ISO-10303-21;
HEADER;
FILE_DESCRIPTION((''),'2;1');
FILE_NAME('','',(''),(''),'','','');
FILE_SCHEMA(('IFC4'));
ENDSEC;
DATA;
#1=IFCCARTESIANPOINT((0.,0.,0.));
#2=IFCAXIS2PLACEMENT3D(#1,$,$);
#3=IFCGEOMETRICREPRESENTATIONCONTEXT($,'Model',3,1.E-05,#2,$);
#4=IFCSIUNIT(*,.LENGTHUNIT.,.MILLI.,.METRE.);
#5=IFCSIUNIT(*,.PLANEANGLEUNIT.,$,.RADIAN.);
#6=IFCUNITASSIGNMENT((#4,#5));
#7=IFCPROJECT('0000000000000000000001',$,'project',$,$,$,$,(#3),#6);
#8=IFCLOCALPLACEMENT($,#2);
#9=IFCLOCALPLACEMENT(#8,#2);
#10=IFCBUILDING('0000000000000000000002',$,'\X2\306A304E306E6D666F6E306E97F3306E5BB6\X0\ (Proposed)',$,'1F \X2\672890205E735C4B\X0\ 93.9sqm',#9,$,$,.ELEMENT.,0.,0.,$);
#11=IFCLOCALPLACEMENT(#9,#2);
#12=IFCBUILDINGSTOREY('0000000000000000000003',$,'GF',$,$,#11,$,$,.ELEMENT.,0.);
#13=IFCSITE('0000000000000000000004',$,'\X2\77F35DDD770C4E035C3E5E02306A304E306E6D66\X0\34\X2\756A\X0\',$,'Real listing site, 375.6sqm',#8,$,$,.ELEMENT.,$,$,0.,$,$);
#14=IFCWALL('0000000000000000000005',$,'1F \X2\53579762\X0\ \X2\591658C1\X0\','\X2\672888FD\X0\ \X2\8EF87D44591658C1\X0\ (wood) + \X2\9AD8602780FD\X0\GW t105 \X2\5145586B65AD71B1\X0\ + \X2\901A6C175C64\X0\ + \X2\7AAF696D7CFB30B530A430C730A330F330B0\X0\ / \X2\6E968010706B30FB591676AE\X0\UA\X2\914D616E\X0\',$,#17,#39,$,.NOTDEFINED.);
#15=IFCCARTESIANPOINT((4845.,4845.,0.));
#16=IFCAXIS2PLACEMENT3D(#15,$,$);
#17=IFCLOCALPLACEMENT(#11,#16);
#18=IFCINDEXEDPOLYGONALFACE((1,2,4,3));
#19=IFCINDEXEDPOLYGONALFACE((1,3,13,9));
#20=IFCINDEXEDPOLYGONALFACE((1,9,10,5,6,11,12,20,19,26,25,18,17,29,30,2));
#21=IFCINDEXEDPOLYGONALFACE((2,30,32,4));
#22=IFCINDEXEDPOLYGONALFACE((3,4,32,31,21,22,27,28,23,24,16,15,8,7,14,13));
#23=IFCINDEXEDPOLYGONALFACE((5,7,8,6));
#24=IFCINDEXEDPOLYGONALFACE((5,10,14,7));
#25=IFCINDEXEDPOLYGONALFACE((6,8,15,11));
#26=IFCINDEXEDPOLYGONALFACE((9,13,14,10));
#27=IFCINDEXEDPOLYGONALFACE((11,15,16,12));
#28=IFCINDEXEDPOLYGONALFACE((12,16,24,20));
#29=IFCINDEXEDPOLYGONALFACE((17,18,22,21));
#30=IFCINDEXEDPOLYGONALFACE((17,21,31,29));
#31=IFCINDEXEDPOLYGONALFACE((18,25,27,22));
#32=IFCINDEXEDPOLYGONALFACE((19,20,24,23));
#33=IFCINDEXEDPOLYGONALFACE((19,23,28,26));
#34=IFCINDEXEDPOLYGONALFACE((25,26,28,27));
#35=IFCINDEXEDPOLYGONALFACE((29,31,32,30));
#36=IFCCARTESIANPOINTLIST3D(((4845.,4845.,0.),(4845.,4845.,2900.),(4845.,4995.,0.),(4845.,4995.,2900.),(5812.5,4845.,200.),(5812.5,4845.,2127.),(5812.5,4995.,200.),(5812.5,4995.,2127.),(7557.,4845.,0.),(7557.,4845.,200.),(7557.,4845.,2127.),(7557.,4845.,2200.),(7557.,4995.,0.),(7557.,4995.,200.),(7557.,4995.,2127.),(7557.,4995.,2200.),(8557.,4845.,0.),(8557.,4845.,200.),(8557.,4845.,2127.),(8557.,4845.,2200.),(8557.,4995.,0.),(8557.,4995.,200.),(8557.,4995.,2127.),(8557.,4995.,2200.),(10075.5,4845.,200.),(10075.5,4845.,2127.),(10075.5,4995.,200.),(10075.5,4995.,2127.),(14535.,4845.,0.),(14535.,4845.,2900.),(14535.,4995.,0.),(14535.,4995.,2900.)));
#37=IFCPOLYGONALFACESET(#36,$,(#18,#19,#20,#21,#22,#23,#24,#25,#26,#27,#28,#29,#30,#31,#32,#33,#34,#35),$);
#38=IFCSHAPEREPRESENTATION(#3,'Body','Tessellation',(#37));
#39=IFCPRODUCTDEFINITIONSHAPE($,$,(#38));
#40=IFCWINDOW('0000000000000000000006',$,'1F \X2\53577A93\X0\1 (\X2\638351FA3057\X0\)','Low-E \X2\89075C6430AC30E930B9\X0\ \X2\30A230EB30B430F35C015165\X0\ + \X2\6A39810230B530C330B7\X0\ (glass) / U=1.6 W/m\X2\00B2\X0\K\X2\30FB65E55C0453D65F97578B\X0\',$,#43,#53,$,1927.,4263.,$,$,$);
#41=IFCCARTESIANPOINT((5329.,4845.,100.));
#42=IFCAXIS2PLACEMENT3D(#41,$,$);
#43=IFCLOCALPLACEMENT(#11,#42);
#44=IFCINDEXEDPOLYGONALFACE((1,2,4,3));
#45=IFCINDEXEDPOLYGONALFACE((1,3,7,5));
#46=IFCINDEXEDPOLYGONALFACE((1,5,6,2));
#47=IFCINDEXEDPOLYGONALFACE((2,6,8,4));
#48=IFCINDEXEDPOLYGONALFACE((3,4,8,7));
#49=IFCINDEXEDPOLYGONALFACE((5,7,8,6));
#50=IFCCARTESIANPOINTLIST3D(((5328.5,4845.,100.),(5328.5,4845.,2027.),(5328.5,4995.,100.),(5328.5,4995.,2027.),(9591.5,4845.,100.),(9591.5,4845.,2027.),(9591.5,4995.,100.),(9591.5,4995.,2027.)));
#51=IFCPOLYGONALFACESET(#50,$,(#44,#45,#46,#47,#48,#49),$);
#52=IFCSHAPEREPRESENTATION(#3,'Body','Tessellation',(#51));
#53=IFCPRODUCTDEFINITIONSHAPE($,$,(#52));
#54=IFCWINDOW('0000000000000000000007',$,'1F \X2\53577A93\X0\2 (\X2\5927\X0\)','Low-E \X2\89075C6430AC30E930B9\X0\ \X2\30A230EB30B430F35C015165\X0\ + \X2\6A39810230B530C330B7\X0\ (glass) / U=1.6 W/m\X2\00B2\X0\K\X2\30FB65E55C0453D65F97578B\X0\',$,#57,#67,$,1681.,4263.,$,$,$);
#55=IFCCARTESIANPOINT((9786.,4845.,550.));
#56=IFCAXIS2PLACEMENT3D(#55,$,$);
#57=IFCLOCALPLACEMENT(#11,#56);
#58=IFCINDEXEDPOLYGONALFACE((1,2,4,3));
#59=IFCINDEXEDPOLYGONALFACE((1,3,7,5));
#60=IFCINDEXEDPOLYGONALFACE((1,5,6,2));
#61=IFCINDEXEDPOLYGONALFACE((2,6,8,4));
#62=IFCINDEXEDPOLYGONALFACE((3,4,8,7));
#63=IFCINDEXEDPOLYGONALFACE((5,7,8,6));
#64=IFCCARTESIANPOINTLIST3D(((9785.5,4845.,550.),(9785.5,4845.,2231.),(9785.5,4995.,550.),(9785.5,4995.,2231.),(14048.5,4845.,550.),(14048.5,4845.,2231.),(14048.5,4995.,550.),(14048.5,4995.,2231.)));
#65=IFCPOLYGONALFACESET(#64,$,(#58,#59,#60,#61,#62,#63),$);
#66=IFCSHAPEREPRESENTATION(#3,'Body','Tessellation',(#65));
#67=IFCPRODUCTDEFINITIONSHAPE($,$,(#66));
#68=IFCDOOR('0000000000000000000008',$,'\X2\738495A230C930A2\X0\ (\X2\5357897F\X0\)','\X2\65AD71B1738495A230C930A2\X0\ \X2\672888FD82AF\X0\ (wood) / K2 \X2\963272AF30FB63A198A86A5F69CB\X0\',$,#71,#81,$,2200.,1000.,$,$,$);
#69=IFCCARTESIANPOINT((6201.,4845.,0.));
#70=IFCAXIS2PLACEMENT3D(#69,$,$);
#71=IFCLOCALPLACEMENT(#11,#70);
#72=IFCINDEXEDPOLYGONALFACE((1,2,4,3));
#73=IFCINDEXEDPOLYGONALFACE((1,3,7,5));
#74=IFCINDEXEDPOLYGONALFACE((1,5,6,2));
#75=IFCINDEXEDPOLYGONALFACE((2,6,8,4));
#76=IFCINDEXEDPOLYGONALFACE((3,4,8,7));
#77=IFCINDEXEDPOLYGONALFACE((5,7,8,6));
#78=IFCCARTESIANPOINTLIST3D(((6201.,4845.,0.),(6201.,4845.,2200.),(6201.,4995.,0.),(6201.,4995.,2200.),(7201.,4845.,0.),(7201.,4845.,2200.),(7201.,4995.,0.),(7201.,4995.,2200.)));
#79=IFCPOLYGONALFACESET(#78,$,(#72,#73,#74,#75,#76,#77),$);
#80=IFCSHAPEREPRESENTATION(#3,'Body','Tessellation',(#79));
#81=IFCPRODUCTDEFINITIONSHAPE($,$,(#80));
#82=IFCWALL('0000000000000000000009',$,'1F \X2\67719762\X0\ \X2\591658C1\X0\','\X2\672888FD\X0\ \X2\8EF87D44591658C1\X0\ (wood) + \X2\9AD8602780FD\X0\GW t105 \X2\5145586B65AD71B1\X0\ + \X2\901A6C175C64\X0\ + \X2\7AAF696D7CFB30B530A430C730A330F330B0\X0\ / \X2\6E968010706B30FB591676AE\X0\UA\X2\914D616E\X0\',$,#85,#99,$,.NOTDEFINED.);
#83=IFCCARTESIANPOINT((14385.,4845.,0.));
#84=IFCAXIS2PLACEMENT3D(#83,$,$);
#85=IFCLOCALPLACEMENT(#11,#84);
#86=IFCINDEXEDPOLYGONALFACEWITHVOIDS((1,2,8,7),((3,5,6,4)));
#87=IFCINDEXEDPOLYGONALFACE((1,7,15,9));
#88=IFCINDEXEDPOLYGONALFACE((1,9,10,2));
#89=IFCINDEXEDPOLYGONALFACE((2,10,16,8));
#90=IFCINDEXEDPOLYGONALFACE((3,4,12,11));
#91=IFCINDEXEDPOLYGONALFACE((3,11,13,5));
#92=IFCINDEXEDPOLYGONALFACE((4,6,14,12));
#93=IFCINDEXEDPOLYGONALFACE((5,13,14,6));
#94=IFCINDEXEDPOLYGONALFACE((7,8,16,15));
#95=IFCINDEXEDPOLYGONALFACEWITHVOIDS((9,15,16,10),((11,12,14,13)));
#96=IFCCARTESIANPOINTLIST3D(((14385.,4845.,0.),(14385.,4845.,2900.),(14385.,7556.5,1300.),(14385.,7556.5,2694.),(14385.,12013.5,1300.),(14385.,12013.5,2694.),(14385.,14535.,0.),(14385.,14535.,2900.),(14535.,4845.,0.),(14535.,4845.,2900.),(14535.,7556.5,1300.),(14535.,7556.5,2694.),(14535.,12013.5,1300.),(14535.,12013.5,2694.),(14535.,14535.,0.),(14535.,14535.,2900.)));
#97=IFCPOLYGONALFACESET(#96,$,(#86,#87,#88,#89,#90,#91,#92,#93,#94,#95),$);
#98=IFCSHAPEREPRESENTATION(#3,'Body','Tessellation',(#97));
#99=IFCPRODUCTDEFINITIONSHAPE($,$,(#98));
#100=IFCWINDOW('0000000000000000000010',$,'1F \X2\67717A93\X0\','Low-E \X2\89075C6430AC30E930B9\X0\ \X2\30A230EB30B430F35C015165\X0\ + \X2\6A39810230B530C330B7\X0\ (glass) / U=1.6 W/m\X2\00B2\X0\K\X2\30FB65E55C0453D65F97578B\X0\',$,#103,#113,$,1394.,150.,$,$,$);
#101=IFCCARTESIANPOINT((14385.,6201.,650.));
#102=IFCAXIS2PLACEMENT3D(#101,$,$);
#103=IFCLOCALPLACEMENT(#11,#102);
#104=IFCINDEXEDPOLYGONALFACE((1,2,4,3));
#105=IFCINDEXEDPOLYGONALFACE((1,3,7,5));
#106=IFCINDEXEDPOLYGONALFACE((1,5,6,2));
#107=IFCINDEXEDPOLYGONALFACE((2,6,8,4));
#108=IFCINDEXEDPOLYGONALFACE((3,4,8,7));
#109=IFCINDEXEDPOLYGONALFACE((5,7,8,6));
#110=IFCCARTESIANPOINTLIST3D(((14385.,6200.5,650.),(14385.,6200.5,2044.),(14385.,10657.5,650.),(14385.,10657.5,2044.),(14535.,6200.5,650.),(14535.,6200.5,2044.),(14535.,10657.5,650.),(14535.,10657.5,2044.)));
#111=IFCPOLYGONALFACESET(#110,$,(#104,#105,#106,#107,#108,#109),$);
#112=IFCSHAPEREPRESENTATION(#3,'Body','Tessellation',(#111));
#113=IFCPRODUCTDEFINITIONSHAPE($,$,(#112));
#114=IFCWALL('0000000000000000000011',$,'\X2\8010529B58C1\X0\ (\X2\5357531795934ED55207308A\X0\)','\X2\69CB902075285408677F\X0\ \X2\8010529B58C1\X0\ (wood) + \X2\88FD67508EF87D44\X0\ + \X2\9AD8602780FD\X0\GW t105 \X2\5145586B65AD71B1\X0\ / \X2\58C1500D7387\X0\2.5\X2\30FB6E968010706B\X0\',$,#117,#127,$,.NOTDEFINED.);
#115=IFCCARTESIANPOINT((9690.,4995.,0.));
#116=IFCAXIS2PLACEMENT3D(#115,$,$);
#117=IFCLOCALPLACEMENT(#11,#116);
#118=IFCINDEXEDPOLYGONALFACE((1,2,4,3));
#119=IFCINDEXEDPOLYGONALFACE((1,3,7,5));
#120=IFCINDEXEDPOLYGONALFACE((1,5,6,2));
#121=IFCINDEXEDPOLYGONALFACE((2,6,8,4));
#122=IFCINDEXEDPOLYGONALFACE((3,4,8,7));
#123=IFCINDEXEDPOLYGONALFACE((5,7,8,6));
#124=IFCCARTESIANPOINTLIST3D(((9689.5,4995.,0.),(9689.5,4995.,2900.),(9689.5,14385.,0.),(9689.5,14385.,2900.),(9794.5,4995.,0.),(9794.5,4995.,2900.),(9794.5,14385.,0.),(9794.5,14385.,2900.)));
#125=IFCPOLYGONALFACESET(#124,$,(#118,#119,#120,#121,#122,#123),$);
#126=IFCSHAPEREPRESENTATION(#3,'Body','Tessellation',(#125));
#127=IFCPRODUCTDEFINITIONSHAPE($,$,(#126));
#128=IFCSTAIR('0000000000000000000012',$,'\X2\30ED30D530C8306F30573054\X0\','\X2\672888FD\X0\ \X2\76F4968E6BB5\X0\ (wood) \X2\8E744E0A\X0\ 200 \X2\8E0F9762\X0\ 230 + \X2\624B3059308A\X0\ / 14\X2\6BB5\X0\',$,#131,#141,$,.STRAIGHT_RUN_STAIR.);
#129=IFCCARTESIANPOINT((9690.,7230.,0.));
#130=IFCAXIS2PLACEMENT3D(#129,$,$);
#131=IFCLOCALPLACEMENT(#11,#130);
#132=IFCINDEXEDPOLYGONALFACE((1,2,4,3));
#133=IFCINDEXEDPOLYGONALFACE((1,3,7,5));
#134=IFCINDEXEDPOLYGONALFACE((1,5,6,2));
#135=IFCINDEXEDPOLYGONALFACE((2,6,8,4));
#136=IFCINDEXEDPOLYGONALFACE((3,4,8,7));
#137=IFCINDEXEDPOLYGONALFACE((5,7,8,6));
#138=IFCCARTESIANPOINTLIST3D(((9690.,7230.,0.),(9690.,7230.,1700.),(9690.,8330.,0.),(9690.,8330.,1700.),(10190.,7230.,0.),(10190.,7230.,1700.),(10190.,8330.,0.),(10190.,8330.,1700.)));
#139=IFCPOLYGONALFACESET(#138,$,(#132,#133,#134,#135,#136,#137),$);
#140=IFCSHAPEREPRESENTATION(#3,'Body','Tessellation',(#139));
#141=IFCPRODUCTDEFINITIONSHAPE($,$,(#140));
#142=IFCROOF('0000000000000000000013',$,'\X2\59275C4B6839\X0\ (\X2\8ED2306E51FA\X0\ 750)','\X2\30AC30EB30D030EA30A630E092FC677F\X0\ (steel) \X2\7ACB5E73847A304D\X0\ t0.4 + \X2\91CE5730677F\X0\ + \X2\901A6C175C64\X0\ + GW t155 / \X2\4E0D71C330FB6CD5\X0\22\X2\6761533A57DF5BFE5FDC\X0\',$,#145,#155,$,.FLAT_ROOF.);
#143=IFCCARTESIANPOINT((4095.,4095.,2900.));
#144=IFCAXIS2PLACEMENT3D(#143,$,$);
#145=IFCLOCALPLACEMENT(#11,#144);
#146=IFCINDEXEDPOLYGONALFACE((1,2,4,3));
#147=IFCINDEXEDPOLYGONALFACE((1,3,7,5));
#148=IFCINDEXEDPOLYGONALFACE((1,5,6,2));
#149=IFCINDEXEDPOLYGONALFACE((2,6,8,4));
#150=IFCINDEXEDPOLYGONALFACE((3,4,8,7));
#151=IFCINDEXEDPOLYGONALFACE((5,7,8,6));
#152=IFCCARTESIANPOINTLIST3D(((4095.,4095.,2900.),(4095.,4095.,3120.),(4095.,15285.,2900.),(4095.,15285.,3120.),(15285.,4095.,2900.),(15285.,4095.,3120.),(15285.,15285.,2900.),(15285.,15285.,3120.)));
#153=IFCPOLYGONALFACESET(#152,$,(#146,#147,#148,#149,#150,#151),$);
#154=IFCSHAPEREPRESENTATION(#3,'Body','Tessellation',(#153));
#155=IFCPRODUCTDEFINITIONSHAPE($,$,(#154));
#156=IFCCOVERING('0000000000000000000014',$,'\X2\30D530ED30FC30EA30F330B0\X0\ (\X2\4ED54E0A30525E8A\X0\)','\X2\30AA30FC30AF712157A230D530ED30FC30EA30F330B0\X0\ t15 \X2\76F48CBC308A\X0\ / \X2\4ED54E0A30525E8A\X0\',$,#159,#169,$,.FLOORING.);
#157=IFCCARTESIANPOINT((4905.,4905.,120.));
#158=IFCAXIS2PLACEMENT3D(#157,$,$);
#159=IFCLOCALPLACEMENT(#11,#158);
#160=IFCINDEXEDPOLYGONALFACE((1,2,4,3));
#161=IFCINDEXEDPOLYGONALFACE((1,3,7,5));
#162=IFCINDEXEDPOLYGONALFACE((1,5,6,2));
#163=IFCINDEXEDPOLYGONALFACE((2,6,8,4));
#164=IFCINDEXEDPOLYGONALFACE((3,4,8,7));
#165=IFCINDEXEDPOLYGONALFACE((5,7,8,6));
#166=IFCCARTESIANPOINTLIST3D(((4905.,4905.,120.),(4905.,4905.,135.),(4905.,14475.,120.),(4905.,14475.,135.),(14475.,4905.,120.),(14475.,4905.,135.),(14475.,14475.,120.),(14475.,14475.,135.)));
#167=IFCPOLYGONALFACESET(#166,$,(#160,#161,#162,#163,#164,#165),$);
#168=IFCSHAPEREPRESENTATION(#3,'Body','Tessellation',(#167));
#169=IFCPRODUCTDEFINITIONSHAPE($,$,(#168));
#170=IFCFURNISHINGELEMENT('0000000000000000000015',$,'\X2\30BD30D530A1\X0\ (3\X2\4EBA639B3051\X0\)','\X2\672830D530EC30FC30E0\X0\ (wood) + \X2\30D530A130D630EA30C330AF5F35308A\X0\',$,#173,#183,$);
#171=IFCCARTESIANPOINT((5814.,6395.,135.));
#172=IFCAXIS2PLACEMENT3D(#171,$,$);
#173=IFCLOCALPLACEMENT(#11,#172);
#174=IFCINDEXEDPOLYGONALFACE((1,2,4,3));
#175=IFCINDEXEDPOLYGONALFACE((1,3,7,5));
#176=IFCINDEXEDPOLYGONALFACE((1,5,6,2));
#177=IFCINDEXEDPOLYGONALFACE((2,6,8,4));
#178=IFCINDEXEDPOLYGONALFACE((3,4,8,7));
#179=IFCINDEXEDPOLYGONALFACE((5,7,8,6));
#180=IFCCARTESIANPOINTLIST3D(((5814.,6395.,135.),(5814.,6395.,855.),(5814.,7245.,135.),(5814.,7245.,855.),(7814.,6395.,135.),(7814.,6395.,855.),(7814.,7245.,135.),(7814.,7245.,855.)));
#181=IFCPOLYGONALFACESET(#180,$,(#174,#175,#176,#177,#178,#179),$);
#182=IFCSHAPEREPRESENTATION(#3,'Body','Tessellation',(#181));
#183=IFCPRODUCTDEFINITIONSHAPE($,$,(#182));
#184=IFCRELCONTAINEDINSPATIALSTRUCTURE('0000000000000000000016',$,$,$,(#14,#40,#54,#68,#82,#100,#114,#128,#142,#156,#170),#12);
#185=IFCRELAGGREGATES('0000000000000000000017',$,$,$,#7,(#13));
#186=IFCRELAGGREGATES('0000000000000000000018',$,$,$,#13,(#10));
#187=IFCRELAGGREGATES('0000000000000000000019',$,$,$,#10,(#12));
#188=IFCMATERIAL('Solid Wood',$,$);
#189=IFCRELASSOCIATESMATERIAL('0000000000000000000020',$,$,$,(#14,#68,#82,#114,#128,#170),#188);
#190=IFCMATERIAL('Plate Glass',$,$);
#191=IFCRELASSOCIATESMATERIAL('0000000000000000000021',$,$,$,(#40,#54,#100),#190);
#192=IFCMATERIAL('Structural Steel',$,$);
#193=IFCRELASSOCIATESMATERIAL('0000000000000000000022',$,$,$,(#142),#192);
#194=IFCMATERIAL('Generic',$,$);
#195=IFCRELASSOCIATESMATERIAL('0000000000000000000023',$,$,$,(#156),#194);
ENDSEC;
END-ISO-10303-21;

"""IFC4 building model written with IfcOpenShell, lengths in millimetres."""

from ifc_helpers import new_model, si_unit, frame, frame_2d, origin, place, context, project, spatial, rectangle, extrude, material, element, fill, save


model = new_model("IFC4")

# Units and contexts
model_context = context("Model", 3, precision=1e-05, world=origin())
ifc_project = project(units=[si_unit("LENGTHUNIT", "METRE", prefix="MILLI"), si_unit("PLANEANGLEUNIT", "RADIAN")], contexts=[model_context])

# Site, building, storey
site_placement = place(None, origin())
site = spatial("IfcSite", under=ifc_project, at=site_placement, Name="石川県七尾市なぎの浦34番", ObjectType="Real listing site, 375.6sqm", CompositionType="ELEMENT", RefElevation=0.0)
building_placement = place(site_placement, origin())
building = spatial("IfcBuilding", under=site, at=building_placement, Name="なぎの浦潮の音の家 (Proposed)", ObjectType="1F 木造平屋 93.9sqm", CompositionType="ELEMENT", ElevationOfRefHeight=0.0, ElevationOfTerrain=0.0)
storey_placement = place(building_placement, origin())
storey = spatial("IfcBuildingStorey", under=building, at=storey_placement, Name="GF", CompositionType="ELEMENT", Elevation=0.0)

# Shared definitions
ifc_material_1 = material(Name="Solid Wood")

# Wall, openings, windows, door
wall_1_placement = place(storey_placement, frame((4845.0, 4845.0, 0.0)))
wall_1 = element("IfcWall", 1, at=wall_1_placement, inside=storey, material=ifc_material_1, Name="1F 南面 外壁", Description="木製 軸組外壁 (wood) + 高性能GW t105 充填断熱 + 通気層 + 窯業系サイディング / 準耐火・外皮UA配慮", PredefinedType="NOTDEFINED", context=model_context, shape_type="SweptSolid", body=[
    extrude(rectangle(XDim=9690.0, YDim=150.0, at=frame_2d((4845.0, 75.0))), frame((4845.0, 4845.0, 0.0)), (0.0, 0.0, 1.0), 2900.0),
])
opening_1_placement = place(storey_placement, frame((5329.0, 4845.0, 100.0)))
opening_1 = element("IfcOpeningElement", 2, at=opening_1_placement, cuts=wall_1, PredefinedType="NOTDEFINED", context=model_context, shape_type="SweptSolid", body=[
    extrude(rectangle(XDim=4263.0, YDim=150.0, at=frame_2d((2131.0, 75.0))), frame((5329.0, 4845.0, 100.0)), (0.0, 0.0, 1.0), 1927.0),
])
opening_2_placement = place(storey_placement, frame((9786.0, 4845.0, 550.0)))
opening_2 = element("IfcOpeningElement", 3, at=opening_2_placement, cuts=wall_1, PredefinedType="NOTDEFINED", context=model_context, shape_type="SweptSolid", body=[
    extrude(rectangle(XDim=4263.0, YDim=150.0, at=frame_2d((2131.0, 75.0))), frame((9786.0, 4845.0, 550.0)), (0.0, 0.0, 1.0), 1681.0),
])
opening_3_placement = place(storey_placement, frame((6201.0, 4845.0, 0.0)))
opening_3 = element("IfcOpeningElement", 4, at=opening_3_placement, cuts=wall_1, PredefinedType="NOTDEFINED", context=model_context, shape_type="SweptSolid", body=[
    extrude(rectangle(XDim=1000.0, YDim=150.0, at=frame_2d((500.0, 75.0))), frame((6201.0, 4845.0, 0.0)), (0.0, 0.0, 1.0), 2200.0),
])
ifc_material_2 = material(Name="Plate Glass")
window_1_placement = place(storey_placement, frame((5329.0, 4845.0, 100.0)))
window_1 = element("IfcWindow", 5, at=window_1_placement, inside=storey, material=ifc_material_2, Name="1F 南窓1 (掃出し)", Description="Low-E 複層ガラス アルゴン封入 + 樹脂サッシ (glass) / U=1.6 W/m²K・日射取得型", OverallHeight=1927.0, OverallWidth=4263.0, context=model_context, shape_type="SweptSolid", body=[
    extrude(rectangle(XDim=4263.0, YDim=150.0, at=frame_2d((2131.0, 75.0))), frame((5329.0, 4845.0, 100.0)), (0.0, 0.0, 1.0), 1927.0),
])
fill(opening_1, window_1)
window_2_placement = place(storey_placement, frame((9786.0, 4845.0, 550.0)))
window_2 = element("IfcWindow", 6, at=window_2_placement, inside=storey, material=ifc_material_2, Name="1F 南窓2 (大)", Description="Low-E 複層ガラス アルゴン封入 + 樹脂サッシ (glass) / U=1.6 W/m²K・日射取得型", OverallHeight=1681.0, OverallWidth=4263.0, context=model_context, shape_type="SweptSolid", body=[
    extrude(rectangle(XDim=4263.0, YDim=150.0, at=frame_2d((2131.0, 75.0))), frame((9786.0, 4845.0, 550.0)), (0.0, 0.0, 1.0), 1681.0),
])
fill(opening_2, window_2)
door_placement = place(storey_placement, frame((6201.0, 4845.0, 0.0)))
door = element("IfcDoor", 7, at=door_placement, inside=storey, material=ifc_material_1, Name="玄関ドア (南西)", Description="断熱玄関ドア 木製芯 (wood) / K2 防犯・採風機構", OverallHeight=2200.0, OverallWidth=1000.0, context=model_context, shape_type="SweptSolid", body=[
    extrude(rectangle(XDim=1000.0, YDim=150.0, at=frame_2d((500.0, 75.0))), frame((6201.0, 4845.0, 0.0)), (0.0, 0.0, 1.0), 2200.0),
])
fill(opening_3, door)

# Wall, opening, window
wall_2_placement = place(storey_placement, frame((14385.0, 4845.0, 0.0)))
wall_2 = element("IfcWall", 8, at=wall_2_placement, inside=storey, material=ifc_material_1, Name="1F 東面 外壁", Description="木製 軸組外壁 (wood) + 高性能GW t105 充填断熱 + 通気層 + 窯業系サイディング / 準耐火・外皮UA配慮", PredefinedType="NOTDEFINED", context=model_context, shape_type="SweptSolid", body=[
    extrude(rectangle(XDim=150.0, YDim=9690.0, at=frame_2d((75.0, 4845.0))), frame((14385.0, 4845.0, 0.0)), (0.0, 0.0, 1.0), 2900.0),
])
opening_4_placement = place(storey_placement, frame((14385.0, 6201.0, 650.0)))
opening_4 = element("IfcOpeningElement", 9, at=opening_4_placement, cuts=wall_2, PredefinedType="NOTDEFINED", context=model_context, shape_type="SweptSolid", body=[
    extrude(rectangle(XDim=150.0, YDim=4457.0, at=frame_2d((75.0, 2228.0))), frame((14385.0, 6201.0, 650.0)), (0.0, 0.0, 1.0), 1394.0),
])
window_3_placement = place(storey_placement, frame((14385.0, 6201.0, 650.0)))
window_3 = element("IfcWindow", 10, at=window_3_placement, inside=storey, material=ifc_material_2, Name="1F 東窓", Description="Low-E 複層ガラス アルゴン封入 + 樹脂サッシ (glass) / U=1.6 W/m²K・日射取得型", OverallHeight=1394.0, OverallWidth=150.0, context=model_context, shape_type="SweptSolid", body=[
    extrude(rectangle(XDim=150.0, YDim=4457.0, at=frame_2d((75.0, 2228.0))), frame((14385.0, 6201.0, 650.0)), (0.0, 0.0, 1.0), 1394.0),
])
fill(opening_4, window_3)

# Wall
wall_3_placement = place(storey_placement, frame((9690.0, 4995.0, 0.0)))
element("IfcWall", 11, at=wall_3_placement, inside=storey, material=ifc_material_1, Name="耐力壁 (南北間仕切り)", Description="構造用合板 耐力壁 (wood) + 製材軸組 + 高性能GW t105 充填断熱 / 壁倍率2.5・準耐火", PredefinedType="NOTDEFINED", context=model_context, shape_type="SweptSolid", body=[
    extrude(rectangle(XDim=105.0, YDim=9390.0, at=frame_2d((52.0, 4695.0))), frame((9690.0, 4995.0, 0.0)), (0.0, 0.0, 1.0), 2900.0),
])

# Stair
stair_placement = place(storey_placement, frame((9690.0, 7230.0, 0.0)))
element("IfcStair", 12, at=stair_placement, inside=storey, material=ifc_material_1, Name="ロフトはしご", Description="木製 直階段 (wood) 蹴上 200 踏面 230 + 手すり / 14段", PredefinedType="STRAIGHT_RUN_STAIR", context=model_context, shape_type="SweptSolid", body=[
    extrude(rectangle(XDim=500.0, YDim=1100.0, at=frame_2d((250.0, 550.0))), frame((9690.0, 7230.0, 0.0)), (0.0, 0.0, 1.0), 1700.0),
])

# Roof
ifc_material_3 = material(Name="Structural Steel")
roof_placement = place(storey_placement, frame((4095.0, 4095.0, 2900.0)))
element("IfcRoof", 13, at=roof_placement, inside=storey, material=ifc_material_3, Name="大屋根 (軒の出 750)", Description="ガルバリウム鋼板 (steel) 立平葺き t0.4 + 野地板 + 通気層 + GW t155 / 不燃・法22条区域対応", PredefinedType="FLAT_ROOF", context=model_context, shape_type="SweptSolid", body=[
    extrude(rectangle(XDim=11190.0, YDim=11190.0, at=frame_2d((5595.0, 5595.0))), frame((4095.0, 4095.0, 2900.0)), (0.0, 0.0, 1.0), 220.0),
])

# Covering
ifc_material_4 = material(Name="Generic")
covering_placement = place(storey_placement, frame((4905.0, 4905.0, 120.0)))
element("IfcCovering", 14, at=covering_placement, inside=storey, material=ifc_material_4, Name="フローリング (仕上げ床)", Description="オーク無垢フローリング t15 直貼り / 仕上げ床", PredefinedType="FLOORING", context=model_context, shape_type="SweptSolid", body=[
    extrude(rectangle(XDim=9570.0, YDim=9570.0, at=frame_2d((4785.0, 4785.0))), frame((4905.0, 4905.0, 120.0)), (0.0, 0.0, 1.0), 15.0),
])

# Furnishing element
furnishing_1_placement = place(storey_placement, frame((5814.0, 6395.0, 135.0)))
element("IfcFurnishingElement", 15, at=furnishing_1_placement, inside=storey, material=ifc_material_1, Name="ソファ (3人掛け)", Description="木フレーム (wood) + ファブリック張り", context=model_context, shape_type="SweptSolid", body=[
    extrude(rectangle(XDim=2000.0, YDim=850.0, at=frame_2d((1000.0, 425.0))), frame((5814.0, 6395.0, 135.0)), (0.0, 0.0, 1.0), 720.0),
])

save(model, "model.ifc")
